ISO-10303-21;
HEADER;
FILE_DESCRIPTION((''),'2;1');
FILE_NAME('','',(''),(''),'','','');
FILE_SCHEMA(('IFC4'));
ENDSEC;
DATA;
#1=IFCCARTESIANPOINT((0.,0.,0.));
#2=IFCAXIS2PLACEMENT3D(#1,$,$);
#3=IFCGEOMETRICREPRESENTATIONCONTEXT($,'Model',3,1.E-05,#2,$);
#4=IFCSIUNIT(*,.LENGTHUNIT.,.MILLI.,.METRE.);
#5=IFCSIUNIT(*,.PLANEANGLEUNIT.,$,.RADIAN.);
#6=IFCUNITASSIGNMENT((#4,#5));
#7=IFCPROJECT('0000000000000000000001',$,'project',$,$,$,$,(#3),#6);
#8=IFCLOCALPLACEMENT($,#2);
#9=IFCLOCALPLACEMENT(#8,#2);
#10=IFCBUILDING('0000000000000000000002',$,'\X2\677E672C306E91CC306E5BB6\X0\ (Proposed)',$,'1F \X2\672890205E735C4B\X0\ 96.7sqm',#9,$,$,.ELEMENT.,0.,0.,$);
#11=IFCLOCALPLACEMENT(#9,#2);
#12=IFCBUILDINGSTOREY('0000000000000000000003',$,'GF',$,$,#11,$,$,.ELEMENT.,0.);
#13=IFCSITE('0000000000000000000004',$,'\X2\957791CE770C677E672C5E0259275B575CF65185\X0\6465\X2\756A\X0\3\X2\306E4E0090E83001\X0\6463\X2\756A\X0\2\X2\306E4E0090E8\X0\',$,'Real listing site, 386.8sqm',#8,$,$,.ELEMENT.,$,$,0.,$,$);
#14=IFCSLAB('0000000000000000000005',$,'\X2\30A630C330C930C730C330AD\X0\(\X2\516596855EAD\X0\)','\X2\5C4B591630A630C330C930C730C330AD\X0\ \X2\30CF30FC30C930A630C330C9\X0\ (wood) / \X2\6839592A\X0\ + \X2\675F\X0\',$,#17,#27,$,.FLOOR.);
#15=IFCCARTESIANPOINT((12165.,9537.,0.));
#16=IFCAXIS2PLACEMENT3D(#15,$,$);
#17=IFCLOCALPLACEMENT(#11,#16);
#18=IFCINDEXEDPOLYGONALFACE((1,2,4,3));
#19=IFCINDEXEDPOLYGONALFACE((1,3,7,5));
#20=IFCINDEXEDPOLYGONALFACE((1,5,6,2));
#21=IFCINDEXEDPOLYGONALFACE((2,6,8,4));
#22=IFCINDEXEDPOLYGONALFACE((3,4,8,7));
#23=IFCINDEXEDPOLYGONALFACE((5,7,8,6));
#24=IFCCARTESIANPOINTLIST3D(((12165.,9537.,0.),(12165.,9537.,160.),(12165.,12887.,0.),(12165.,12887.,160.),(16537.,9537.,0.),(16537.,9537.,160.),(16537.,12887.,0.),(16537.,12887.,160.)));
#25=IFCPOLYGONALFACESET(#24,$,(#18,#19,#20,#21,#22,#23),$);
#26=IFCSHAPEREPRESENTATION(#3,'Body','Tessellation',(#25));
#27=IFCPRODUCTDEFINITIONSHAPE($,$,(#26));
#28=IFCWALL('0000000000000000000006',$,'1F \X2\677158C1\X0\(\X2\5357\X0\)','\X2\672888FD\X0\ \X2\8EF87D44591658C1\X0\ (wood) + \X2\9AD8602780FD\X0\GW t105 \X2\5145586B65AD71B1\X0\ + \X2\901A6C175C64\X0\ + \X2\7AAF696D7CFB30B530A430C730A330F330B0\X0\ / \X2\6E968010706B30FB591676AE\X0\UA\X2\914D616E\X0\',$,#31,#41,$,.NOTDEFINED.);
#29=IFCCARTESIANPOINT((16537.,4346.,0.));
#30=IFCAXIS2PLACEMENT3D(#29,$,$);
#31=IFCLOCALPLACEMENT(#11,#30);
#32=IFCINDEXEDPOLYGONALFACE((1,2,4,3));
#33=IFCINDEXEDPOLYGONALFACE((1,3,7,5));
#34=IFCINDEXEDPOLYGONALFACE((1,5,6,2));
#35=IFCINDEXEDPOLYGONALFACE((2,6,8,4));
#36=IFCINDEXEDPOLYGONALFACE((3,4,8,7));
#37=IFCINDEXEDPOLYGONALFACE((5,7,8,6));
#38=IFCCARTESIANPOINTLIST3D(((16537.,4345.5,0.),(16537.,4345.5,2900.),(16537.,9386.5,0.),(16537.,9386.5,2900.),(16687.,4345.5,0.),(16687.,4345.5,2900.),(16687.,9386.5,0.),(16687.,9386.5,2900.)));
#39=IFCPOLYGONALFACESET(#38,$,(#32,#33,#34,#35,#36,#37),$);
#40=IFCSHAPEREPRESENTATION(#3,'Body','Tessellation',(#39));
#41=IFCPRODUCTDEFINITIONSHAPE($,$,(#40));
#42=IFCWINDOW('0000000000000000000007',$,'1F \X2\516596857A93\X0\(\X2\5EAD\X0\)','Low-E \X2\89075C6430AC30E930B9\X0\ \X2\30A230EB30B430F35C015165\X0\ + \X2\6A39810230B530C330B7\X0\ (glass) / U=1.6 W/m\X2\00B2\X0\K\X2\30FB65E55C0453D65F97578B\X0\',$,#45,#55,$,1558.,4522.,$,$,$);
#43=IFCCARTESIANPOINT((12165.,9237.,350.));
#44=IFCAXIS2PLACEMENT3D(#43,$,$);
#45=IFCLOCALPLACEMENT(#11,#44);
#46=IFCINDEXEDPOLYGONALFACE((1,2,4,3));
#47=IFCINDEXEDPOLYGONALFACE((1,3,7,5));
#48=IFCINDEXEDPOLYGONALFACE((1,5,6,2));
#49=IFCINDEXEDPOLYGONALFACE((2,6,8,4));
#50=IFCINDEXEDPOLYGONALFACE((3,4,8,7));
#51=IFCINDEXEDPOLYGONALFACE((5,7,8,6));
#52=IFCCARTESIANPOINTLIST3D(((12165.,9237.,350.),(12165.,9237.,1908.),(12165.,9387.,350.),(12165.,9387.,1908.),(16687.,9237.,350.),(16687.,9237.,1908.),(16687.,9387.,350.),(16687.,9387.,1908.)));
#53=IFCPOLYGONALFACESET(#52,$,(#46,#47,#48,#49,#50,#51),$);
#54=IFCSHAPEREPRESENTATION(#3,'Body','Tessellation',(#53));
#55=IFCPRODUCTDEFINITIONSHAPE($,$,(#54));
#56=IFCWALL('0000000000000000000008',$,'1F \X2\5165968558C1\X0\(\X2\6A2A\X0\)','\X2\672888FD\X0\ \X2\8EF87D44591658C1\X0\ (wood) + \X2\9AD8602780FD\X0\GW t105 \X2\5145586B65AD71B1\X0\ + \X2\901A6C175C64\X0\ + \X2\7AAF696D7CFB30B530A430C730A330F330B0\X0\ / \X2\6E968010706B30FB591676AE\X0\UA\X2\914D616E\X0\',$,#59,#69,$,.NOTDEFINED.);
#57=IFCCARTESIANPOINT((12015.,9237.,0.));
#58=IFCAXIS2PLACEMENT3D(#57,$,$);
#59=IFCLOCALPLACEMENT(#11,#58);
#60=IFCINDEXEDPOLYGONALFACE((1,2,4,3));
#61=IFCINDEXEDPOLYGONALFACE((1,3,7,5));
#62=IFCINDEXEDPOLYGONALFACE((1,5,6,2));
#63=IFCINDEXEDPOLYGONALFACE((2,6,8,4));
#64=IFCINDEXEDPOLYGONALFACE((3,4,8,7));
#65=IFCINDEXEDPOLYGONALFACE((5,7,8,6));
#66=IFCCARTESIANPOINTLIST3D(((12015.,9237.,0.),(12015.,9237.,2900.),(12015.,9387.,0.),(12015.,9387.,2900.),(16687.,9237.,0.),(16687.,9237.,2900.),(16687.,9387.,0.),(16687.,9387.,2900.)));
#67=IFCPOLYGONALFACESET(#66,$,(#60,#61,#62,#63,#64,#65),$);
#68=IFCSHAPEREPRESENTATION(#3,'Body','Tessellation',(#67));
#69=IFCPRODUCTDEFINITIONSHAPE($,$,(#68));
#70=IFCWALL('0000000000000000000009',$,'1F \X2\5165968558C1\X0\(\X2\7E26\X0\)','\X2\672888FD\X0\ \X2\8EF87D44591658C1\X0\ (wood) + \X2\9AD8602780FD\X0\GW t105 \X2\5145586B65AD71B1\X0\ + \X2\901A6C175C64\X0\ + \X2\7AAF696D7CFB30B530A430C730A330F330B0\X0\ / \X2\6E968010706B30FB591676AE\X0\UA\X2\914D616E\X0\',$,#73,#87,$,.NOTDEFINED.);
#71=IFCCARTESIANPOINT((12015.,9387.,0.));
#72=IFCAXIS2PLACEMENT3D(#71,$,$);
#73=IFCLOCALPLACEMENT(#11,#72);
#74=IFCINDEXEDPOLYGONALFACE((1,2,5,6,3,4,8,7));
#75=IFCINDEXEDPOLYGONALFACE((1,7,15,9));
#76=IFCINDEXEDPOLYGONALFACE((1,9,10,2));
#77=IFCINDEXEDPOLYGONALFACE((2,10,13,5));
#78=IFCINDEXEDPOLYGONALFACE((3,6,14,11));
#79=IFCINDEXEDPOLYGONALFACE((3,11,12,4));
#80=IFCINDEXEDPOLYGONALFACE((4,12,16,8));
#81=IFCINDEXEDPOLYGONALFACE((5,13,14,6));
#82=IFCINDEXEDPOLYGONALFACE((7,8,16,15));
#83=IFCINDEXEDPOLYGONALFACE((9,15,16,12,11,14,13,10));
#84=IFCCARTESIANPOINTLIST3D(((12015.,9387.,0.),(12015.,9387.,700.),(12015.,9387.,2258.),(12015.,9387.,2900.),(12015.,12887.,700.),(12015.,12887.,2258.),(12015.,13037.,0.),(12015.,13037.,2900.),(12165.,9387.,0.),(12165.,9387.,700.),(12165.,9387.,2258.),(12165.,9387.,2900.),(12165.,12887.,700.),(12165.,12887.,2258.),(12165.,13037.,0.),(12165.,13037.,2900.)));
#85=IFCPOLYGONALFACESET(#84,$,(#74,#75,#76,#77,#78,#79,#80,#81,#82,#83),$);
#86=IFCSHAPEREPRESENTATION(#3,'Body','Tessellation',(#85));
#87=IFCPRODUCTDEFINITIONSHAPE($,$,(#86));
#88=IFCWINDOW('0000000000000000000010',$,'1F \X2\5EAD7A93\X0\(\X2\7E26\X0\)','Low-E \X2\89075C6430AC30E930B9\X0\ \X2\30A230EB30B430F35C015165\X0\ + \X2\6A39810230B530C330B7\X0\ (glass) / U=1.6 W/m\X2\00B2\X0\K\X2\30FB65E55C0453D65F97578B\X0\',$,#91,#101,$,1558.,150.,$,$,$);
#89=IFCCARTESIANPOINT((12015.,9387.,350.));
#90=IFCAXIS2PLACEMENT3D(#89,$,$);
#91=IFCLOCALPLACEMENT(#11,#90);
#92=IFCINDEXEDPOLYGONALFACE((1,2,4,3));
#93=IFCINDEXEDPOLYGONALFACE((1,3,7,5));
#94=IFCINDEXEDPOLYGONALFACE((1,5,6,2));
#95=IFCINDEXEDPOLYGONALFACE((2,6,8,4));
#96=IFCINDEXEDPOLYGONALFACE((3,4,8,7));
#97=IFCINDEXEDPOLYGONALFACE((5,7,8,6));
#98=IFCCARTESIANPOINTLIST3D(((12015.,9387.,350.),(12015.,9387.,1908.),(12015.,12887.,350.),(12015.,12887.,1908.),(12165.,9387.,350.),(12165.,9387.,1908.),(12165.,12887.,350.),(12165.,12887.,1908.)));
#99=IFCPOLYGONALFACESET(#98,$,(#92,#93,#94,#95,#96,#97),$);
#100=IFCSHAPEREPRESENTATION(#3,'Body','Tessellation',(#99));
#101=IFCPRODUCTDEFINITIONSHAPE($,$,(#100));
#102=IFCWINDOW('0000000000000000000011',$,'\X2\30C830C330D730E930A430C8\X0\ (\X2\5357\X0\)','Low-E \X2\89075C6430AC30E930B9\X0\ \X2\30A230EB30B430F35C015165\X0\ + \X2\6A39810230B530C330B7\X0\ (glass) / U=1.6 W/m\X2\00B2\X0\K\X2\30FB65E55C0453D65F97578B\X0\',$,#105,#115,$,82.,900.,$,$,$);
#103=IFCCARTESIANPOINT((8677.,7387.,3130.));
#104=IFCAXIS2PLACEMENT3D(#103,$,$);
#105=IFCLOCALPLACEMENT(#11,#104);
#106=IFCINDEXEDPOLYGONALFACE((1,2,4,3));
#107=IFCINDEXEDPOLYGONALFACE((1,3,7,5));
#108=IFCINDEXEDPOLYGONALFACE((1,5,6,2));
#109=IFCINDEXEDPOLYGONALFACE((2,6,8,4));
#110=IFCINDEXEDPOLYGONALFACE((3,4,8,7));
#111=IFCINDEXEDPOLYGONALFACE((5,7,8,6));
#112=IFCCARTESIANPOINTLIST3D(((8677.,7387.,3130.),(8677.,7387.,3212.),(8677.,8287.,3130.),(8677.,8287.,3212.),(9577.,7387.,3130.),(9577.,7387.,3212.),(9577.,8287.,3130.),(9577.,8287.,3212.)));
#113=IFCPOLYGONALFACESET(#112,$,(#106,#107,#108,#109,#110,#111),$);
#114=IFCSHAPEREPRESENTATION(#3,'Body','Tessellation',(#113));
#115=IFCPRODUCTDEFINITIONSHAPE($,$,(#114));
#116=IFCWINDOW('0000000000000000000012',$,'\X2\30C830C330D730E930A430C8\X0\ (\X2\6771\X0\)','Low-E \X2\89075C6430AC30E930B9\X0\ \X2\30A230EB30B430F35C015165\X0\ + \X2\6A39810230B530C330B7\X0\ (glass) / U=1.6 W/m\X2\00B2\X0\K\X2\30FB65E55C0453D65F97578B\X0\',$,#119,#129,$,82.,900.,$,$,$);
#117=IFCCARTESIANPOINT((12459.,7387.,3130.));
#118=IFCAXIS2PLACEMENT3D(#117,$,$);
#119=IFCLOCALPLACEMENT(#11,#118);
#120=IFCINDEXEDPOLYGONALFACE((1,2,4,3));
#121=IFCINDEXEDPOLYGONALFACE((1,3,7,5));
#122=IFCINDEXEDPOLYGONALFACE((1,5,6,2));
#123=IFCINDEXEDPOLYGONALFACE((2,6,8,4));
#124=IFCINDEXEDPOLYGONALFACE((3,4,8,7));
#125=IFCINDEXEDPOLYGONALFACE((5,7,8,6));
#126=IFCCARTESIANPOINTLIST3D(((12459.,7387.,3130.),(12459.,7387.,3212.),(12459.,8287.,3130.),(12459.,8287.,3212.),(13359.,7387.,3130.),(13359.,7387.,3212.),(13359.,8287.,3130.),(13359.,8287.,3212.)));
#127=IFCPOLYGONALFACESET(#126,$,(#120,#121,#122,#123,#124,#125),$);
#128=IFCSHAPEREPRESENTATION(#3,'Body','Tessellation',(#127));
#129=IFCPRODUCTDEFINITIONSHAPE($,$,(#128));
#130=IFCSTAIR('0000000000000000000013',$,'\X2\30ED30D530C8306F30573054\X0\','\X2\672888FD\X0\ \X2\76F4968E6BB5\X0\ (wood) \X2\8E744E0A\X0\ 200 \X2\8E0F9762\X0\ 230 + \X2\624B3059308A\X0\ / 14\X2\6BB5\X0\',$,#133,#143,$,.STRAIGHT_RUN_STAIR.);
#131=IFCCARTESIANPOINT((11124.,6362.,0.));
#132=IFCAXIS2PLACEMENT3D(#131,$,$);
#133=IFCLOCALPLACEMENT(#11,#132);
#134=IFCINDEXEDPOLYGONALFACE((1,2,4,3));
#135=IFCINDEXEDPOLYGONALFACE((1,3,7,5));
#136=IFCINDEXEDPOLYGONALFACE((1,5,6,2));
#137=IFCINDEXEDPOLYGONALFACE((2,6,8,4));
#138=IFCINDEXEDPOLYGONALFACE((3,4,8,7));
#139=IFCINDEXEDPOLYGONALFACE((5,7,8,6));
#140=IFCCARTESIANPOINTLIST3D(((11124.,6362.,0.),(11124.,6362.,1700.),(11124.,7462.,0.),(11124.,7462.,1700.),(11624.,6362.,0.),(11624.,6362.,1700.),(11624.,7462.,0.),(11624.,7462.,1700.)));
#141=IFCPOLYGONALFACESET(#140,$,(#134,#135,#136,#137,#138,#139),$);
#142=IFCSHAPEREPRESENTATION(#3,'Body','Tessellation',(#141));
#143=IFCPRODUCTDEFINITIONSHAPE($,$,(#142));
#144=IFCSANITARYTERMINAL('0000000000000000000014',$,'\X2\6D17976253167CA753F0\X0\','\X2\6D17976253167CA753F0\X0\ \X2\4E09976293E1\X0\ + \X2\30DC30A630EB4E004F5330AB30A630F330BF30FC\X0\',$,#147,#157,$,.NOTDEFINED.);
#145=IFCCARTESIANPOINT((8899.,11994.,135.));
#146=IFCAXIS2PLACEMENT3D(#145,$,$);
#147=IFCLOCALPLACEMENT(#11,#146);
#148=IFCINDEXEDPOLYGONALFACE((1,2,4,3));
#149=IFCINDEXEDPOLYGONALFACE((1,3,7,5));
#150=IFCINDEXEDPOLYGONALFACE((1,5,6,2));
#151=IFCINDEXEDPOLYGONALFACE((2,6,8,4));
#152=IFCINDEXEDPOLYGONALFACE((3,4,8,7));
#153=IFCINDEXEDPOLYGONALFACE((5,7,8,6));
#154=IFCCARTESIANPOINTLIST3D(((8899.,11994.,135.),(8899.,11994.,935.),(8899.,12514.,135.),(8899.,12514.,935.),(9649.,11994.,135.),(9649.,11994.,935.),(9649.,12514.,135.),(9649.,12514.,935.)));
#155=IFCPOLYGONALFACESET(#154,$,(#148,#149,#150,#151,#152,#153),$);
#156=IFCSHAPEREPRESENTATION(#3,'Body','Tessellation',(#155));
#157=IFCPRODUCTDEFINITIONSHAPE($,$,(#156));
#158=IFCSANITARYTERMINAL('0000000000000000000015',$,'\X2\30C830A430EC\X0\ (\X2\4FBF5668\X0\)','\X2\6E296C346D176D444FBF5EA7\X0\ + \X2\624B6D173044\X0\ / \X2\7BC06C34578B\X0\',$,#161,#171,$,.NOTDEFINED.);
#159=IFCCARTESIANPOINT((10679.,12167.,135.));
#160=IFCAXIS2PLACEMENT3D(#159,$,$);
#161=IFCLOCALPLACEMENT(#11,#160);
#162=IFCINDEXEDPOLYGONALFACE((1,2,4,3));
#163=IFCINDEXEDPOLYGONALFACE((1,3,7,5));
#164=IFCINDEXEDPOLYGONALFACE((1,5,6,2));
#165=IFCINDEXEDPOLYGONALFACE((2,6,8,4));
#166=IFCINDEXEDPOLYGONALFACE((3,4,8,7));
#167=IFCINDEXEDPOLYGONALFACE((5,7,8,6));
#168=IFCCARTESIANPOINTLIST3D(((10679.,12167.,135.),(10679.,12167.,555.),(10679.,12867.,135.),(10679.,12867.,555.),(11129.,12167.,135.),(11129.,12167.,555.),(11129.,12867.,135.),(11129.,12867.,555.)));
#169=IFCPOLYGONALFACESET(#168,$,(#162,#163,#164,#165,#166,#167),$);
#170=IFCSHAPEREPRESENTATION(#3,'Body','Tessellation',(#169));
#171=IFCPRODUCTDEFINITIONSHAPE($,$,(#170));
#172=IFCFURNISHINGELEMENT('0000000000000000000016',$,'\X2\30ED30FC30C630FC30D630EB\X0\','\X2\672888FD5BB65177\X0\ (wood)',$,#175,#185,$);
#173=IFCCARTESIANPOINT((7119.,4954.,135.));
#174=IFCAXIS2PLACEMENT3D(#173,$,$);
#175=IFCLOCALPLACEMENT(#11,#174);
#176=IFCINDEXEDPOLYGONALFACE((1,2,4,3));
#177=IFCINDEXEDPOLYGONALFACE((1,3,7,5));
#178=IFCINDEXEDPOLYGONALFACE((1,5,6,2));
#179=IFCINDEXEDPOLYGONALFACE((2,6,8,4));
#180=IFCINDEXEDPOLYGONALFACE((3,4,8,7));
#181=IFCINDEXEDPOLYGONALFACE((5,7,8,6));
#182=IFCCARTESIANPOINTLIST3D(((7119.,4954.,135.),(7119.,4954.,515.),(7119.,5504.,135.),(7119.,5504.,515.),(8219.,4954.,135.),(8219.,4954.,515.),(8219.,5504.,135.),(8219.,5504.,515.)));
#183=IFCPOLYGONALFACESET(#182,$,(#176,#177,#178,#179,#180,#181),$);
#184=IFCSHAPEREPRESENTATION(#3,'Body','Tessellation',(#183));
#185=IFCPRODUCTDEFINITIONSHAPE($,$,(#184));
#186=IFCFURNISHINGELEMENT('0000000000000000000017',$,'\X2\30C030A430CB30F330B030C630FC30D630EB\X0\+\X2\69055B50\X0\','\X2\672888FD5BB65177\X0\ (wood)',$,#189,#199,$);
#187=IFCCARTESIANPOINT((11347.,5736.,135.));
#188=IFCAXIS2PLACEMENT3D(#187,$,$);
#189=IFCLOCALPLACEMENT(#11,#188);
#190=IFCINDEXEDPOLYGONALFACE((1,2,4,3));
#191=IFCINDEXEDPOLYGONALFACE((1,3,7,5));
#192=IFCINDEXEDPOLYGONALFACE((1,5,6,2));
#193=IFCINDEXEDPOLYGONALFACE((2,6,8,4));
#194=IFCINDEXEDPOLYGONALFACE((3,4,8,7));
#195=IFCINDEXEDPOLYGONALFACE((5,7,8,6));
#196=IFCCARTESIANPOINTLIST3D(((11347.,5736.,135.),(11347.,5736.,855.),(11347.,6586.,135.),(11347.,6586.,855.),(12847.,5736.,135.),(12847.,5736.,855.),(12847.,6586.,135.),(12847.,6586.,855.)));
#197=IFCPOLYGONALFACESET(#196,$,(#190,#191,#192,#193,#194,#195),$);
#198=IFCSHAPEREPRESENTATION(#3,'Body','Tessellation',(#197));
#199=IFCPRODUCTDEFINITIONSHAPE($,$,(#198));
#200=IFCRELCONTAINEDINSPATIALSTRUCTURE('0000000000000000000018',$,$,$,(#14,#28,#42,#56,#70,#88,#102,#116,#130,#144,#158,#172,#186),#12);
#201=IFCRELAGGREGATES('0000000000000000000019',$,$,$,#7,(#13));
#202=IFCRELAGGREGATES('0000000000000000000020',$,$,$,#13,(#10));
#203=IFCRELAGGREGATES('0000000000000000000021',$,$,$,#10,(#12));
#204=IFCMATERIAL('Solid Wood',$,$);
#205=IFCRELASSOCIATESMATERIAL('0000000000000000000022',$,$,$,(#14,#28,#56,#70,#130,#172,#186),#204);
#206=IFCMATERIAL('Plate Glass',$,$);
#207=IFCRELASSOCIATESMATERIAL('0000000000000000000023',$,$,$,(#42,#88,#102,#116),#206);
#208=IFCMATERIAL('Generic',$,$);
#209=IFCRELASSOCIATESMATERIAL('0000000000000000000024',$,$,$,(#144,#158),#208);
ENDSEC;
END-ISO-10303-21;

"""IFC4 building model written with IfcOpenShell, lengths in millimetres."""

from ifc_helpers import new_model, si_unit, frame, frame_2d, origin, place, context, project, spatial, rectangle, extrude, material, element, fill, save


model = new_model("IFC4")

# Units and contexts
model_context = context("Model", 3, precision=1e-05, world=origin())
ifc_project = project(units=[si_unit("LENGTHUNIT", "METRE", prefix="MILLI"), si_unit("PLANEANGLEUNIT", "RADIAN")], contexts=[model_context])

# Site, building, storey
site_placement = place(None, origin())
site = spatial("IfcSite", under=ifc_project, at=site_placement, Name="長野県松本市大字島内6465番3の一部、6463番2の一部", ObjectType="Real listing site, 386.8sqm", CompositionType="ELEMENT", RefElevation=0.0)
building_placement = place(site_placement, origin())
building = spatial("IfcBuilding", under=site, at=building_placement, Name="松本の里の家 (Proposed)", ObjectType="1F 木造平屋 96.7sqm", CompositionType="ELEMENT", ElevationOfRefHeight=0.0, ElevationOfTerrain=0.0)
storey_placement = place(building_placement, origin())
storey = spatial("IfcBuildingStorey", under=building, at=storey_placement, Name="GF", CompositionType="ELEMENT", Elevation=0.0)

# Slab
ifc_material_1 = material(Name="Solid Wood")
slab_placement = place(storey_placement, frame((12165.0, 9537.0, 0.0)))
element("IfcSlab", 1, at=slab_placement, inside=storey, material=ifc_material_1, Name="ウッドデッキ(入隅庭)", Description="屋外ウッドデッキ ハードウッド (wood) / 根太 + 束", PredefinedType="FLOOR", context=model_context, shape_type="SweptSolid", body=[
    extrude(rectangle(XDim=4372.0, YDim=3350.0, at=frame_2d((2186.0, 1675.0))), frame((12165.0, 9537.0, 0.0)), (0.0, 0.0, 1.0), 160.0),
])

# Wall, opening, window
wall_1_placement = place(storey_placement, frame((16537.0, 4346.0, 0.0)))
wall_1 = element("IfcWall", 2, at=wall_1_placement, inside=storey, material=ifc_material_1, Name="1F 東壁(南)", Description="木製 軸組外壁 (wood) + 高性能GW t105 充填断熱 + 通気層 + 窯業系サイディング / 準耐火・外皮UA配慮", PredefinedType="NOTDEFINED", context=model_context, shape_type="SweptSolid", body=[
    extrude(rectangle(XDim=150.0, YDim=5041.0, at=frame_2d((75.0, 2520.0))), frame((16537.0, 4346.0, 0.0)), (0.0, 0.0, 1.0), 2900.0),
])
opening_1_placement = place(storey_placement, frame((12165.0, 9237.0, 350.0)))
opening_1 = element("IfcOpeningElement", 3, at=opening_1_placement, cuts=wall_1, PredefinedType="NOTDEFINED", context=model_context, shape_type="SweptSolid", body=[
    extrude(rectangle(XDim=4522.0, YDim=150.0, at=frame_2d((2261.0, 75.0))), frame((12165.0, 9237.0, 350.0)), (0.0, 0.0, 1.0), 1558.0),
])
ifc_material_2 = material(Name="Plate Glass")
window_1_placement = place(storey_placement, frame((12165.0, 9237.0, 350.0)))
window_1 = element("IfcWindow", 4, at=window_1_placement, inside=storey, material=ifc_material_2, Name="1F 入隅窓(庭)", Description="Low-E 複層ガラス アルゴン封入 + 樹脂サッシ (glass) / U=1.6 W/m²K・日射取得型", OverallHeight=1558.0, OverallWidth=4522.0, context=model_context, shape_type="SweptSolid", body=[
    extrude(rectangle(XDim=4522.0, YDim=150.0, at=frame_2d((2261.0, 75.0))), frame((12165.0, 9237.0, 350.0)), (0.0, 0.0, 1.0), 1558.0),
])
fill(opening_1, window_1)

# Wall
wall_2_placement = place(storey_placement, frame((12015.0, 9237.0, 0.0)))
element("IfcWall", 5, at=wall_2_placement, inside=storey, material=ifc_material_1, Name="1F 入隅壁(横)", Description="木製 軸組外壁 (wood) + 高性能GW t105 充填断熱 + 通気層 + 窯業系サイディング / 準耐火・外皮UA配慮", PredefinedType="NOTDEFINED", context=model_context, shape_type="SweptSolid", body=[
    extrude(rectangle(XDim=4672.0, YDim=150.0, at=frame_2d((2336.0, 75.0))), frame((12015.0, 9237.0, 0.0)), (0.0, 0.0, 1.0), 2900.0),
])

# Wall, opening, window
wall_3_placement = place(storey_placement, frame((12015.0, 9387.0, 0.0)))
wall_3 = element("IfcWall", 6, at=wall_3_placement, inside=storey, material=ifc_material_1, Name="1F 入隅壁(縦)", Description="木製 軸組外壁 (wood) + 高性能GW t105 充填断熱 + 通気層 + 窯業系サイディング / 準耐火・外皮UA配慮", PredefinedType="NOTDEFINED", context=model_context, shape_type="SweptSolid", body=[
    extrude(rectangle(XDim=150.0, YDim=3650.0, at=frame_2d((75.0, 1825.0))), frame((12015.0, 9387.0, 0.0)), (0.0, 0.0, 1.0), 2900.0),
])
opening_2_placement = place(storey_placement, frame((12015.0, 9387.0, 350.0)))
opening_2 = element("IfcOpeningElement", 7, at=opening_2_placement, cuts=wall_3, PredefinedType="NOTDEFINED", context=model_context, shape_type="SweptSolid", body=[
    extrude(rectangle(XDim=150.0, YDim=3500.0, at=frame_2d((75.0, 1750.0))), frame((12015.0, 9387.0, 350.0)), (0.0, 0.0, 1.0), 1558.0),
])
window_2_placement = place(storey_placement, frame((12015.0, 9387.0, 350.0)))
window_2 = element("IfcWindow", 8, at=window_2_placement, inside=storey, material=ifc_material_2, Name="1F 庭窓(縦)", Description="Low-E 複層ガラス アルゴン封入 + 樹脂サッシ (glass) / U=1.6 W/m²K・日射取得型", OverallHeight=1558.0, OverallWidth=150.0, context=model_context, shape_type="SweptSolid", body=[
    extrude(rectangle(XDim=150.0, YDim=3500.0, at=frame_2d((75.0, 1750.0))), frame((12015.0, 9387.0, 350.0)), (0.0, 0.0, 1.0), 1558.0),
])
fill(opening_2, window_2)

# Windows
window_3_placement = place(storey_placement, frame((8677.0, 7387.0, 3130.0)))
element("IfcWindow", 9, at=window_3_placement, inside=storey, material=ifc_material_2, Name="トップライト (南)", Description="Low-E 複層ガラス アルゴン封入 + 樹脂サッシ (glass) / U=1.6 W/m²K・日射取得型", OverallHeight=82.0, OverallWidth=900.0, context=model_context, shape_type="SweptSolid", body=[
    extrude(rectangle(XDim=900.0, YDim=900.0, at=frame_2d((450.0, 450.0))), frame((8677.0, 7387.0, 3130.0)), (0.0, 0.0, 1.0), 82.0),
])
window_4_placement = place(storey_placement, frame((12459.0, 7387.0, 3130.0)))
element("IfcWindow", 10, at=window_4_placement, inside=storey, material=ifc_material_2, Name="トップライト (東)", Description="Low-E 複層ガラス アルゴン封入 + 樹脂サッシ (glass) / U=1.6 W/m²K・日射取得型", OverallHeight=82.0, OverallWidth=900.0, context=model_context, shape_type="SweptSolid", body=[
    extrude(rectangle(XDim=900.0, YDim=900.0, at=frame_2d((450.0, 450.0))), frame((12459.0, 7387.0, 3130.0)), (0.0, 0.0, 1.0), 82.0),
])

# Stair
stair_placement = place(storey_placement, frame((11124.0, 6362.0, 0.0)))
element("IfcStair", 11, at=stair_placement, inside=storey, material=ifc_material_1, Name="ロフトはしご", Description="木製 直階段 (wood) 蹴上 200 踏面 230 + 手すり / 14段", PredefinedType="STRAIGHT_RUN_STAIR", context=model_context, shape_type="SweptSolid", body=[
    extrude(rectangle(XDim=500.0, YDim=1100.0, at=frame_2d((250.0, 550.0))), frame((11124.0, 6362.0, 0.0)), (0.0, 0.0, 1.0), 1700.0),
])

# Sanitary terminals
ifc_material_3 = material(Name="Generic")
sanitary_terminal_1_placement = place(storey_placement, frame((8899.0, 11994.0, 135.0)))
element("IfcSanitaryTerminal", 12, at=sanitary_terminal_1_placement, inside=storey, material=ifc_material_3, Name="洗面化粧台", Description="洗面化粧台 三面鏡 + ボウル一体カウンター", PredefinedType="NOTDEFINED", context=model_context, shape_type="SweptSolid", body=[
    extrude(rectangle(XDim=750.0, YDim=520.0, at=frame_2d((375.0, 260.0))), frame((8899.0, 11994.0, 135.0)), (0.0, 0.0, 1.0), 800.0),
])
sanitary_terminal_2_placement = place(storey_placement, frame((10679.0, 12167.0, 135.0)))
element("IfcSanitaryTerminal", 13, at=sanitary_terminal_2_placement, inside=storey, material=ifc_material_3, Name="トイレ (便器)", Description="温水洗浄便座 + 手洗い / 節水型", PredefinedType="NOTDEFINED", context=model_context, shape_type="SweptSolid", body=[
    extrude(rectangle(XDim=450.0, YDim=700.0, at=frame_2d((225.0, 350.0))), frame((10679.0, 12167.0, 135.0)), (0.0, 0.0, 1.0), 420.0),
])

# Furnishing elements
furnishing_1_placement = place(storey_placement, frame((7119.0, 4954.0, 135.0)))
element("IfcFurnishingElement", 14, at=furnishing_1_placement, inside=storey, material=ifc_material_1, Name="ローテーブル", Description="木製家具 (wood)", context=model_context, shape_type="SweptSolid", body=[
    extrude(rectangle(XDim=1100.0, YDim=550.0, at=frame_2d((550.0, 275.0))), frame((7119.0, 4954.0, 135.0)), (0.0, 0.0, 1.0), 380.0),
])
furnishing_2_placement = place(storey_placement, frame((11347.0, 5736.0, 135.0)))
element("IfcFurnishingElement", 15, at=furnishing_2_placement, inside=storey, material=ifc_material_1, Name="ダイニングテーブル+椅子", Description="木製家具 (wood)", context=model_context, shape_type="SweptSolid", body=[
    extrude(rectangle(XDim=1500.0, YDim=850.0, at=frame_2d((750.0, 425.0))), frame((11347.0, 5736.0, 135.0)), (0.0, 0.0, 1.0), 720.0),
])

save(model, "model.ifc")
